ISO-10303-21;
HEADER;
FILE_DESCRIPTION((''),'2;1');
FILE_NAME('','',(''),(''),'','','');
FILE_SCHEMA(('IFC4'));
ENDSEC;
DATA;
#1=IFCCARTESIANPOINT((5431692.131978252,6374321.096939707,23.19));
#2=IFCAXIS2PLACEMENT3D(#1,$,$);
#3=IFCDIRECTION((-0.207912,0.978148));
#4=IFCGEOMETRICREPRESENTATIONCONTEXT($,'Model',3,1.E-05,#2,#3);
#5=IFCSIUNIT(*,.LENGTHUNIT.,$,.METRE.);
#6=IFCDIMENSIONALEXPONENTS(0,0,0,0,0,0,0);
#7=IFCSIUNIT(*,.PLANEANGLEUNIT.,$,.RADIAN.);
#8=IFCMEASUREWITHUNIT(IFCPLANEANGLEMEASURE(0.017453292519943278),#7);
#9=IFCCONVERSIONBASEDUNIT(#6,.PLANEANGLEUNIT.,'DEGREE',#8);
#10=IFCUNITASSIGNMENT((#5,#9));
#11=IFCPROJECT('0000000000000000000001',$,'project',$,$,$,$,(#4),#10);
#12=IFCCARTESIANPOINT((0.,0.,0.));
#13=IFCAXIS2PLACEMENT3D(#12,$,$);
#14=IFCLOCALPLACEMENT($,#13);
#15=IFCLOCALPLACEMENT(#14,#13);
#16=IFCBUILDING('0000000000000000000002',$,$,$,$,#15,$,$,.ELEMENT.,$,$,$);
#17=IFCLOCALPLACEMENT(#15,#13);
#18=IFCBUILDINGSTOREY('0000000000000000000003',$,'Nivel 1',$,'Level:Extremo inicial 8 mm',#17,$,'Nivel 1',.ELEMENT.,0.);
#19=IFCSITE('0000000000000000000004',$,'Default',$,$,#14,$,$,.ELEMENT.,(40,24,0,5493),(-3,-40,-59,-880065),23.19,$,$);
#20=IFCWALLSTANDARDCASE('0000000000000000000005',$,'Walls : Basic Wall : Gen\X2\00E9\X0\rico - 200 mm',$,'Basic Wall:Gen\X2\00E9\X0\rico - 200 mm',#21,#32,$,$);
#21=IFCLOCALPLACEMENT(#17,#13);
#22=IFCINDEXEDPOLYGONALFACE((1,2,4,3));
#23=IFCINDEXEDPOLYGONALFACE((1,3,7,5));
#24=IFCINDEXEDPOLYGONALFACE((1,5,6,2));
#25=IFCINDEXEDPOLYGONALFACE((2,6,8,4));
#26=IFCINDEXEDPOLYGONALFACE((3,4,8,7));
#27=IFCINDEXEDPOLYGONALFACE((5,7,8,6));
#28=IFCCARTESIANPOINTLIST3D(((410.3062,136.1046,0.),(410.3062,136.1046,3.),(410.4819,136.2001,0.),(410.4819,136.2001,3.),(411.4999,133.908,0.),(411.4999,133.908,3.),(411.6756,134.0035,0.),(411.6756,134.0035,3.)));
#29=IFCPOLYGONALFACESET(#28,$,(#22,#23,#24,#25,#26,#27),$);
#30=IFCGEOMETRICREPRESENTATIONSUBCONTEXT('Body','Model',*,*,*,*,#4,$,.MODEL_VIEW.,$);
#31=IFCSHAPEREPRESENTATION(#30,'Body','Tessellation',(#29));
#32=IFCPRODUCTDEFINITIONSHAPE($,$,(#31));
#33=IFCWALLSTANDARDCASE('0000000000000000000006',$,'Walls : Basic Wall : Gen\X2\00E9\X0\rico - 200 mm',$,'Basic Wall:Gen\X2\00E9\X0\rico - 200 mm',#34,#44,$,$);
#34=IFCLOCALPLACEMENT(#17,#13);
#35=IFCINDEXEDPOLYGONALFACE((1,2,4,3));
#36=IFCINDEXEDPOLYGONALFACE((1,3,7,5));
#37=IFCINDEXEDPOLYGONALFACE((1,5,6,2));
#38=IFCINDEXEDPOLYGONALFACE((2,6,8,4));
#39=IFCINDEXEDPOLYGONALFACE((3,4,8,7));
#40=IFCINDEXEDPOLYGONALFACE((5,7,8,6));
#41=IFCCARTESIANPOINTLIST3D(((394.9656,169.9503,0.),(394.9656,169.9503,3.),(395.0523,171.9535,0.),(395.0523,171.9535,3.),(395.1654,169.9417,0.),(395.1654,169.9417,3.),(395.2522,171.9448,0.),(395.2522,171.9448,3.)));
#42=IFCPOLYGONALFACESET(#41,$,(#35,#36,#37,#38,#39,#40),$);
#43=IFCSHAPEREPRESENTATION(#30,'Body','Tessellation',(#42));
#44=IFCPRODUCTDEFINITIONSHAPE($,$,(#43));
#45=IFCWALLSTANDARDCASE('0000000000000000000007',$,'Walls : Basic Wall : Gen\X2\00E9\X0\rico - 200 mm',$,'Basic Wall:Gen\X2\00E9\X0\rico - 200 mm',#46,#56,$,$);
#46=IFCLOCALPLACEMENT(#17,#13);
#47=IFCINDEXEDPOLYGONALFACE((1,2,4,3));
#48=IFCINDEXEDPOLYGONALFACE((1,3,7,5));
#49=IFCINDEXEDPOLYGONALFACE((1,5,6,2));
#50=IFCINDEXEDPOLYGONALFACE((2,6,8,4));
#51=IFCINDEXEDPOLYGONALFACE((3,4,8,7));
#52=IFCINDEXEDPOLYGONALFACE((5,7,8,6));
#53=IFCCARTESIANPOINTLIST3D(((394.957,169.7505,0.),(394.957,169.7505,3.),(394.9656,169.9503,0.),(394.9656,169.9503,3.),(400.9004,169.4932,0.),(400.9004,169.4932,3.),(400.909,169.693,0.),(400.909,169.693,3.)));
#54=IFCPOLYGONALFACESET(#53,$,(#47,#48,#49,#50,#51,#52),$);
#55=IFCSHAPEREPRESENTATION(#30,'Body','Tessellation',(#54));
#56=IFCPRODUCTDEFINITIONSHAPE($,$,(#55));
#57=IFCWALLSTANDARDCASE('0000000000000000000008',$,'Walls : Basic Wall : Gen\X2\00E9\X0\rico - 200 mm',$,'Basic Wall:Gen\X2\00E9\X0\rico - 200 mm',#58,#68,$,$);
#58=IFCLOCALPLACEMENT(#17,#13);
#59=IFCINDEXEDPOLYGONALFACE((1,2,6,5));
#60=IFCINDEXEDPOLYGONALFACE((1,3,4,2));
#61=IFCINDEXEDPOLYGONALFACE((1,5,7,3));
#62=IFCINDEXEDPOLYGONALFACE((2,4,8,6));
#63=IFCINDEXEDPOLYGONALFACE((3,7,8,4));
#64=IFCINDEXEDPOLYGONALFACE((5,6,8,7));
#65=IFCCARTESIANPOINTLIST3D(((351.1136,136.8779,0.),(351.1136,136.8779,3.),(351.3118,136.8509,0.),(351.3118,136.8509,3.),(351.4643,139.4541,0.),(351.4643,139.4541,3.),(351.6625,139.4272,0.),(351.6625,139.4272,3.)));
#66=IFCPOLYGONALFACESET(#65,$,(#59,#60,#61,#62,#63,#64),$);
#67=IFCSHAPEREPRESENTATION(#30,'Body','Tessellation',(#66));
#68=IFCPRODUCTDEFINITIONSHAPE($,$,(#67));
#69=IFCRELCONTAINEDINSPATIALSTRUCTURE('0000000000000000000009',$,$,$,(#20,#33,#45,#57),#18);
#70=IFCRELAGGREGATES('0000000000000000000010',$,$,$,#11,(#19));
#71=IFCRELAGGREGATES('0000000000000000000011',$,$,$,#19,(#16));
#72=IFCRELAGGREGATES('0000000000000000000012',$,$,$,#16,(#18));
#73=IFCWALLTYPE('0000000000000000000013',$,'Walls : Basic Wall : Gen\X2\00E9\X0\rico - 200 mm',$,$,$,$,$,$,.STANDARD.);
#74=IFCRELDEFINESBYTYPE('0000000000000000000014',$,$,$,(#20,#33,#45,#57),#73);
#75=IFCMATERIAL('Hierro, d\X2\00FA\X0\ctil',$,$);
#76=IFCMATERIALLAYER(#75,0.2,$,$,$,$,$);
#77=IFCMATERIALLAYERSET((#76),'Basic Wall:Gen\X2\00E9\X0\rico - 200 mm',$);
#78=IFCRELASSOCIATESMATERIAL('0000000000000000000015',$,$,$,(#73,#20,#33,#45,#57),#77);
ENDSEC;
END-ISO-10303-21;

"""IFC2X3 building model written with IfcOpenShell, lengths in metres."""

from ifc_helpers import new_model, entity, si_unit, converted_unit, direction, frame, frame_2d, origin, place, context, subcontext, project, spatial, polyline, rectangle, extrude, clip, bounded_halfspace, material, layer, layer_set, layer_usage, type_object, element, save


model = new_model("IFC2X3")

# Units and contexts
model_context = context("Model", 3, precision=1e-05, world=frame((5431692.131978252, 6374321.096939707, 23.19)), true_north=direction((-0.207912, 0.978148)))
body_context = subcontext(model_context, "Body", "Model", "MODEL_VIEW")
ifc_project = project(units=[si_unit("LENGTHUNIT", "METRE"), converted_unit("PLANEANGLEUNIT", "DEGREE", entity("IfcPlaneAngleMeasure", 0.017453292519943278), si_unit("PLANEANGLEUNIT", "RADIAN"), dimensions=[0, 0, 0, 0, 0, 0, 0])], contexts=[model_context])

# Site, building, storey
site_placement = place(None, origin())
site = spatial("IfcSite", under=ifc_project, at=site_placement, Name="Default", CompositionType="ELEMENT", RefLatitude=(40, 24, 0, 5493), RefLongitude=(-3, -40, -59, -880065), RefElevation=23.19)
building_placement = place(site_placement, origin())
building = spatial("IfcBuilding", under=site, at=building_placement, CompositionType="ELEMENT")
storey_placement = place(building_placement, origin())
storey = spatial("IfcBuildingStorey", under=building, at=storey_placement, Name="Nivel 1", ObjectType="Level:Extremo inicial 8 mm", LongName="Nivel 1", CompositionType="ELEMENT", Elevation=0.0)

# Walls
ifc_material_1 = material(Name="Hierro, dúctil")
ifc_layer_1 = layer(ifc_material_1, 0.2)
ifc_layer_set_1 = layer_set([ifc_layer_1], Name="Basic Wall:Genérico - 200 mm")
wall_type = type_object("IfcWallType", Name="Walls : Basic Wall : Genérico - 200 mm", PredefinedType="STANDARD", material=ifc_layer_set_1)
ifc_layer_usage_1 = layer_usage(ifc_layer_set_1, "AXIS2", "NEGATIVE", 0.1)
wall_1_placement = place(storey_placement, frame((410.394, 136.1524, 0.0), z_axis=(0.0, 0.0, 1.0), x_axis=(0.47748, -0.878643, 0.0)))
element("IfcWallStandardCase", 1, at=wall_1_placement, inside=storey, type_object=wall_type, material=ifc_layer_usage_1, Name="Walls : Basic Wall : Genérico - 200 mm", ObjectType="Basic Wall:Genérico - 200 mm", context=body_context, shape_type="Clipping", body=[
    clip(extrude(rectangle(XDim=2.5, YDim=0.2, at=frame_2d((1.25, 0.0), x_axis=(-1.0, 0.0))), origin(), (0.0, 0.0, 1.0), 3.0), bounded_halfspace(frame((0.0, -0.1, 3.0), z_axis=(0.0, 0.0, 1.0), x_axis=(0.47748, 0.878643, 0.0)), False, frame((0.0, -0.1, 3.0)), polyline([(0.0, 0.0), (2.5, 0.0), (2.5, 0.2), (0.0, 0.2), (0.0, 0.0)]))),
])
ifc_layer_usage_2 = layer_usage(ifc_layer_set_1, "AXIS2", "NEGATIVE", 0.1)
wall_2_placement = place(storey_placement, frame((395.0655, 169.946, 0.0), z_axis=(0.0, 0.0, 1.0), x_axis=(0.043255, 0.999064, 0.0)))
element("IfcWallStandardCase", 2, at=wall_2_placement, inside=storey, type_object=wall_type, material=ifc_layer_usage_2, Name="Walls : Basic Wall : Genérico - 200 mm", ObjectType="Basic Wall:Genérico - 200 mm", context=body_context, shape_type="SweptSolid", body=[
    extrude(rectangle(XDim=2.0051, YDim=0.2, at=frame_2d((1.0025, 0.0), x_axis=(-1.0, 0.0))), origin(), (0.0, 0.0, 1.0), 3.0),
])
ifc_layer_usage_3 = layer_usage(ifc_layer_set_1, "AXIS2", "NEGATIVE", 0.1)
wall_3_placement = place(storey_placement, frame((400.9047, 169.5931, 0.0), z_axis=(0.0, 0.0, 1.0), x_axis=(-0.999064, 0.043255, 0.0)))
element("IfcWallStandardCase", 3, at=wall_3_placement, inside=storey, type_object=wall_type, material=ifc_layer_usage_3, Name="Walls : Basic Wall : Genérico - 200 mm", ObjectType="Basic Wall:Genérico - 200 mm", context=body_context, shape_type="SweptSolid", body=[
    extrude(rectangle(XDim=5.949, YDim=0.2, at=frame_2d((2.9745, 0.0), x_axis=(-1.0, 0.0))), origin(), (0.0, 0.0, 1.0), 3.0),
])
ifc_layer_usage_4 = layer_usage(ifc_layer_set_1, "AXIS2", "NEGATIVE", 0.1)
wall_4_placement = place(storey_placement, frame((351.2127, 136.8644, 0.0), z_axis=(0.0, 0.0, 1.0), x_axis=(0.134876, 0.990862, 0.0)))
element("IfcWallStandardCase", 4, at=wall_4_placement, inside=storey, type_object=wall_type, material=ifc_layer_usage_4, Name="Walls : Basic Wall : Genérico - 200 mm", ObjectType="Basic Wall:Genérico - 200 mm", context=body_context, shape_type="Clipping", body=[
    clip(extrude(rectangle(XDim=2.6, YDim=0.2, at=frame_2d((1.3, 0.0), x_axis=(-1.0, 0.0))), origin(), (0.0, 0.0, 1.0), 3.0), bounded_halfspace(frame((0.0, -0.1, 3.0), z_axis=(0.0, 0.0, 1.0), x_axis=(0.134876, -0.990862, 0.0)), False, frame((0.0, -0.1, 3.0)), polyline([(0.0, 0.0), (2.6, 0.0), (2.6, 0.2), (0.0, 0.2), (0.0, 0.0)]))),
])

save(model, "model.ifc")
